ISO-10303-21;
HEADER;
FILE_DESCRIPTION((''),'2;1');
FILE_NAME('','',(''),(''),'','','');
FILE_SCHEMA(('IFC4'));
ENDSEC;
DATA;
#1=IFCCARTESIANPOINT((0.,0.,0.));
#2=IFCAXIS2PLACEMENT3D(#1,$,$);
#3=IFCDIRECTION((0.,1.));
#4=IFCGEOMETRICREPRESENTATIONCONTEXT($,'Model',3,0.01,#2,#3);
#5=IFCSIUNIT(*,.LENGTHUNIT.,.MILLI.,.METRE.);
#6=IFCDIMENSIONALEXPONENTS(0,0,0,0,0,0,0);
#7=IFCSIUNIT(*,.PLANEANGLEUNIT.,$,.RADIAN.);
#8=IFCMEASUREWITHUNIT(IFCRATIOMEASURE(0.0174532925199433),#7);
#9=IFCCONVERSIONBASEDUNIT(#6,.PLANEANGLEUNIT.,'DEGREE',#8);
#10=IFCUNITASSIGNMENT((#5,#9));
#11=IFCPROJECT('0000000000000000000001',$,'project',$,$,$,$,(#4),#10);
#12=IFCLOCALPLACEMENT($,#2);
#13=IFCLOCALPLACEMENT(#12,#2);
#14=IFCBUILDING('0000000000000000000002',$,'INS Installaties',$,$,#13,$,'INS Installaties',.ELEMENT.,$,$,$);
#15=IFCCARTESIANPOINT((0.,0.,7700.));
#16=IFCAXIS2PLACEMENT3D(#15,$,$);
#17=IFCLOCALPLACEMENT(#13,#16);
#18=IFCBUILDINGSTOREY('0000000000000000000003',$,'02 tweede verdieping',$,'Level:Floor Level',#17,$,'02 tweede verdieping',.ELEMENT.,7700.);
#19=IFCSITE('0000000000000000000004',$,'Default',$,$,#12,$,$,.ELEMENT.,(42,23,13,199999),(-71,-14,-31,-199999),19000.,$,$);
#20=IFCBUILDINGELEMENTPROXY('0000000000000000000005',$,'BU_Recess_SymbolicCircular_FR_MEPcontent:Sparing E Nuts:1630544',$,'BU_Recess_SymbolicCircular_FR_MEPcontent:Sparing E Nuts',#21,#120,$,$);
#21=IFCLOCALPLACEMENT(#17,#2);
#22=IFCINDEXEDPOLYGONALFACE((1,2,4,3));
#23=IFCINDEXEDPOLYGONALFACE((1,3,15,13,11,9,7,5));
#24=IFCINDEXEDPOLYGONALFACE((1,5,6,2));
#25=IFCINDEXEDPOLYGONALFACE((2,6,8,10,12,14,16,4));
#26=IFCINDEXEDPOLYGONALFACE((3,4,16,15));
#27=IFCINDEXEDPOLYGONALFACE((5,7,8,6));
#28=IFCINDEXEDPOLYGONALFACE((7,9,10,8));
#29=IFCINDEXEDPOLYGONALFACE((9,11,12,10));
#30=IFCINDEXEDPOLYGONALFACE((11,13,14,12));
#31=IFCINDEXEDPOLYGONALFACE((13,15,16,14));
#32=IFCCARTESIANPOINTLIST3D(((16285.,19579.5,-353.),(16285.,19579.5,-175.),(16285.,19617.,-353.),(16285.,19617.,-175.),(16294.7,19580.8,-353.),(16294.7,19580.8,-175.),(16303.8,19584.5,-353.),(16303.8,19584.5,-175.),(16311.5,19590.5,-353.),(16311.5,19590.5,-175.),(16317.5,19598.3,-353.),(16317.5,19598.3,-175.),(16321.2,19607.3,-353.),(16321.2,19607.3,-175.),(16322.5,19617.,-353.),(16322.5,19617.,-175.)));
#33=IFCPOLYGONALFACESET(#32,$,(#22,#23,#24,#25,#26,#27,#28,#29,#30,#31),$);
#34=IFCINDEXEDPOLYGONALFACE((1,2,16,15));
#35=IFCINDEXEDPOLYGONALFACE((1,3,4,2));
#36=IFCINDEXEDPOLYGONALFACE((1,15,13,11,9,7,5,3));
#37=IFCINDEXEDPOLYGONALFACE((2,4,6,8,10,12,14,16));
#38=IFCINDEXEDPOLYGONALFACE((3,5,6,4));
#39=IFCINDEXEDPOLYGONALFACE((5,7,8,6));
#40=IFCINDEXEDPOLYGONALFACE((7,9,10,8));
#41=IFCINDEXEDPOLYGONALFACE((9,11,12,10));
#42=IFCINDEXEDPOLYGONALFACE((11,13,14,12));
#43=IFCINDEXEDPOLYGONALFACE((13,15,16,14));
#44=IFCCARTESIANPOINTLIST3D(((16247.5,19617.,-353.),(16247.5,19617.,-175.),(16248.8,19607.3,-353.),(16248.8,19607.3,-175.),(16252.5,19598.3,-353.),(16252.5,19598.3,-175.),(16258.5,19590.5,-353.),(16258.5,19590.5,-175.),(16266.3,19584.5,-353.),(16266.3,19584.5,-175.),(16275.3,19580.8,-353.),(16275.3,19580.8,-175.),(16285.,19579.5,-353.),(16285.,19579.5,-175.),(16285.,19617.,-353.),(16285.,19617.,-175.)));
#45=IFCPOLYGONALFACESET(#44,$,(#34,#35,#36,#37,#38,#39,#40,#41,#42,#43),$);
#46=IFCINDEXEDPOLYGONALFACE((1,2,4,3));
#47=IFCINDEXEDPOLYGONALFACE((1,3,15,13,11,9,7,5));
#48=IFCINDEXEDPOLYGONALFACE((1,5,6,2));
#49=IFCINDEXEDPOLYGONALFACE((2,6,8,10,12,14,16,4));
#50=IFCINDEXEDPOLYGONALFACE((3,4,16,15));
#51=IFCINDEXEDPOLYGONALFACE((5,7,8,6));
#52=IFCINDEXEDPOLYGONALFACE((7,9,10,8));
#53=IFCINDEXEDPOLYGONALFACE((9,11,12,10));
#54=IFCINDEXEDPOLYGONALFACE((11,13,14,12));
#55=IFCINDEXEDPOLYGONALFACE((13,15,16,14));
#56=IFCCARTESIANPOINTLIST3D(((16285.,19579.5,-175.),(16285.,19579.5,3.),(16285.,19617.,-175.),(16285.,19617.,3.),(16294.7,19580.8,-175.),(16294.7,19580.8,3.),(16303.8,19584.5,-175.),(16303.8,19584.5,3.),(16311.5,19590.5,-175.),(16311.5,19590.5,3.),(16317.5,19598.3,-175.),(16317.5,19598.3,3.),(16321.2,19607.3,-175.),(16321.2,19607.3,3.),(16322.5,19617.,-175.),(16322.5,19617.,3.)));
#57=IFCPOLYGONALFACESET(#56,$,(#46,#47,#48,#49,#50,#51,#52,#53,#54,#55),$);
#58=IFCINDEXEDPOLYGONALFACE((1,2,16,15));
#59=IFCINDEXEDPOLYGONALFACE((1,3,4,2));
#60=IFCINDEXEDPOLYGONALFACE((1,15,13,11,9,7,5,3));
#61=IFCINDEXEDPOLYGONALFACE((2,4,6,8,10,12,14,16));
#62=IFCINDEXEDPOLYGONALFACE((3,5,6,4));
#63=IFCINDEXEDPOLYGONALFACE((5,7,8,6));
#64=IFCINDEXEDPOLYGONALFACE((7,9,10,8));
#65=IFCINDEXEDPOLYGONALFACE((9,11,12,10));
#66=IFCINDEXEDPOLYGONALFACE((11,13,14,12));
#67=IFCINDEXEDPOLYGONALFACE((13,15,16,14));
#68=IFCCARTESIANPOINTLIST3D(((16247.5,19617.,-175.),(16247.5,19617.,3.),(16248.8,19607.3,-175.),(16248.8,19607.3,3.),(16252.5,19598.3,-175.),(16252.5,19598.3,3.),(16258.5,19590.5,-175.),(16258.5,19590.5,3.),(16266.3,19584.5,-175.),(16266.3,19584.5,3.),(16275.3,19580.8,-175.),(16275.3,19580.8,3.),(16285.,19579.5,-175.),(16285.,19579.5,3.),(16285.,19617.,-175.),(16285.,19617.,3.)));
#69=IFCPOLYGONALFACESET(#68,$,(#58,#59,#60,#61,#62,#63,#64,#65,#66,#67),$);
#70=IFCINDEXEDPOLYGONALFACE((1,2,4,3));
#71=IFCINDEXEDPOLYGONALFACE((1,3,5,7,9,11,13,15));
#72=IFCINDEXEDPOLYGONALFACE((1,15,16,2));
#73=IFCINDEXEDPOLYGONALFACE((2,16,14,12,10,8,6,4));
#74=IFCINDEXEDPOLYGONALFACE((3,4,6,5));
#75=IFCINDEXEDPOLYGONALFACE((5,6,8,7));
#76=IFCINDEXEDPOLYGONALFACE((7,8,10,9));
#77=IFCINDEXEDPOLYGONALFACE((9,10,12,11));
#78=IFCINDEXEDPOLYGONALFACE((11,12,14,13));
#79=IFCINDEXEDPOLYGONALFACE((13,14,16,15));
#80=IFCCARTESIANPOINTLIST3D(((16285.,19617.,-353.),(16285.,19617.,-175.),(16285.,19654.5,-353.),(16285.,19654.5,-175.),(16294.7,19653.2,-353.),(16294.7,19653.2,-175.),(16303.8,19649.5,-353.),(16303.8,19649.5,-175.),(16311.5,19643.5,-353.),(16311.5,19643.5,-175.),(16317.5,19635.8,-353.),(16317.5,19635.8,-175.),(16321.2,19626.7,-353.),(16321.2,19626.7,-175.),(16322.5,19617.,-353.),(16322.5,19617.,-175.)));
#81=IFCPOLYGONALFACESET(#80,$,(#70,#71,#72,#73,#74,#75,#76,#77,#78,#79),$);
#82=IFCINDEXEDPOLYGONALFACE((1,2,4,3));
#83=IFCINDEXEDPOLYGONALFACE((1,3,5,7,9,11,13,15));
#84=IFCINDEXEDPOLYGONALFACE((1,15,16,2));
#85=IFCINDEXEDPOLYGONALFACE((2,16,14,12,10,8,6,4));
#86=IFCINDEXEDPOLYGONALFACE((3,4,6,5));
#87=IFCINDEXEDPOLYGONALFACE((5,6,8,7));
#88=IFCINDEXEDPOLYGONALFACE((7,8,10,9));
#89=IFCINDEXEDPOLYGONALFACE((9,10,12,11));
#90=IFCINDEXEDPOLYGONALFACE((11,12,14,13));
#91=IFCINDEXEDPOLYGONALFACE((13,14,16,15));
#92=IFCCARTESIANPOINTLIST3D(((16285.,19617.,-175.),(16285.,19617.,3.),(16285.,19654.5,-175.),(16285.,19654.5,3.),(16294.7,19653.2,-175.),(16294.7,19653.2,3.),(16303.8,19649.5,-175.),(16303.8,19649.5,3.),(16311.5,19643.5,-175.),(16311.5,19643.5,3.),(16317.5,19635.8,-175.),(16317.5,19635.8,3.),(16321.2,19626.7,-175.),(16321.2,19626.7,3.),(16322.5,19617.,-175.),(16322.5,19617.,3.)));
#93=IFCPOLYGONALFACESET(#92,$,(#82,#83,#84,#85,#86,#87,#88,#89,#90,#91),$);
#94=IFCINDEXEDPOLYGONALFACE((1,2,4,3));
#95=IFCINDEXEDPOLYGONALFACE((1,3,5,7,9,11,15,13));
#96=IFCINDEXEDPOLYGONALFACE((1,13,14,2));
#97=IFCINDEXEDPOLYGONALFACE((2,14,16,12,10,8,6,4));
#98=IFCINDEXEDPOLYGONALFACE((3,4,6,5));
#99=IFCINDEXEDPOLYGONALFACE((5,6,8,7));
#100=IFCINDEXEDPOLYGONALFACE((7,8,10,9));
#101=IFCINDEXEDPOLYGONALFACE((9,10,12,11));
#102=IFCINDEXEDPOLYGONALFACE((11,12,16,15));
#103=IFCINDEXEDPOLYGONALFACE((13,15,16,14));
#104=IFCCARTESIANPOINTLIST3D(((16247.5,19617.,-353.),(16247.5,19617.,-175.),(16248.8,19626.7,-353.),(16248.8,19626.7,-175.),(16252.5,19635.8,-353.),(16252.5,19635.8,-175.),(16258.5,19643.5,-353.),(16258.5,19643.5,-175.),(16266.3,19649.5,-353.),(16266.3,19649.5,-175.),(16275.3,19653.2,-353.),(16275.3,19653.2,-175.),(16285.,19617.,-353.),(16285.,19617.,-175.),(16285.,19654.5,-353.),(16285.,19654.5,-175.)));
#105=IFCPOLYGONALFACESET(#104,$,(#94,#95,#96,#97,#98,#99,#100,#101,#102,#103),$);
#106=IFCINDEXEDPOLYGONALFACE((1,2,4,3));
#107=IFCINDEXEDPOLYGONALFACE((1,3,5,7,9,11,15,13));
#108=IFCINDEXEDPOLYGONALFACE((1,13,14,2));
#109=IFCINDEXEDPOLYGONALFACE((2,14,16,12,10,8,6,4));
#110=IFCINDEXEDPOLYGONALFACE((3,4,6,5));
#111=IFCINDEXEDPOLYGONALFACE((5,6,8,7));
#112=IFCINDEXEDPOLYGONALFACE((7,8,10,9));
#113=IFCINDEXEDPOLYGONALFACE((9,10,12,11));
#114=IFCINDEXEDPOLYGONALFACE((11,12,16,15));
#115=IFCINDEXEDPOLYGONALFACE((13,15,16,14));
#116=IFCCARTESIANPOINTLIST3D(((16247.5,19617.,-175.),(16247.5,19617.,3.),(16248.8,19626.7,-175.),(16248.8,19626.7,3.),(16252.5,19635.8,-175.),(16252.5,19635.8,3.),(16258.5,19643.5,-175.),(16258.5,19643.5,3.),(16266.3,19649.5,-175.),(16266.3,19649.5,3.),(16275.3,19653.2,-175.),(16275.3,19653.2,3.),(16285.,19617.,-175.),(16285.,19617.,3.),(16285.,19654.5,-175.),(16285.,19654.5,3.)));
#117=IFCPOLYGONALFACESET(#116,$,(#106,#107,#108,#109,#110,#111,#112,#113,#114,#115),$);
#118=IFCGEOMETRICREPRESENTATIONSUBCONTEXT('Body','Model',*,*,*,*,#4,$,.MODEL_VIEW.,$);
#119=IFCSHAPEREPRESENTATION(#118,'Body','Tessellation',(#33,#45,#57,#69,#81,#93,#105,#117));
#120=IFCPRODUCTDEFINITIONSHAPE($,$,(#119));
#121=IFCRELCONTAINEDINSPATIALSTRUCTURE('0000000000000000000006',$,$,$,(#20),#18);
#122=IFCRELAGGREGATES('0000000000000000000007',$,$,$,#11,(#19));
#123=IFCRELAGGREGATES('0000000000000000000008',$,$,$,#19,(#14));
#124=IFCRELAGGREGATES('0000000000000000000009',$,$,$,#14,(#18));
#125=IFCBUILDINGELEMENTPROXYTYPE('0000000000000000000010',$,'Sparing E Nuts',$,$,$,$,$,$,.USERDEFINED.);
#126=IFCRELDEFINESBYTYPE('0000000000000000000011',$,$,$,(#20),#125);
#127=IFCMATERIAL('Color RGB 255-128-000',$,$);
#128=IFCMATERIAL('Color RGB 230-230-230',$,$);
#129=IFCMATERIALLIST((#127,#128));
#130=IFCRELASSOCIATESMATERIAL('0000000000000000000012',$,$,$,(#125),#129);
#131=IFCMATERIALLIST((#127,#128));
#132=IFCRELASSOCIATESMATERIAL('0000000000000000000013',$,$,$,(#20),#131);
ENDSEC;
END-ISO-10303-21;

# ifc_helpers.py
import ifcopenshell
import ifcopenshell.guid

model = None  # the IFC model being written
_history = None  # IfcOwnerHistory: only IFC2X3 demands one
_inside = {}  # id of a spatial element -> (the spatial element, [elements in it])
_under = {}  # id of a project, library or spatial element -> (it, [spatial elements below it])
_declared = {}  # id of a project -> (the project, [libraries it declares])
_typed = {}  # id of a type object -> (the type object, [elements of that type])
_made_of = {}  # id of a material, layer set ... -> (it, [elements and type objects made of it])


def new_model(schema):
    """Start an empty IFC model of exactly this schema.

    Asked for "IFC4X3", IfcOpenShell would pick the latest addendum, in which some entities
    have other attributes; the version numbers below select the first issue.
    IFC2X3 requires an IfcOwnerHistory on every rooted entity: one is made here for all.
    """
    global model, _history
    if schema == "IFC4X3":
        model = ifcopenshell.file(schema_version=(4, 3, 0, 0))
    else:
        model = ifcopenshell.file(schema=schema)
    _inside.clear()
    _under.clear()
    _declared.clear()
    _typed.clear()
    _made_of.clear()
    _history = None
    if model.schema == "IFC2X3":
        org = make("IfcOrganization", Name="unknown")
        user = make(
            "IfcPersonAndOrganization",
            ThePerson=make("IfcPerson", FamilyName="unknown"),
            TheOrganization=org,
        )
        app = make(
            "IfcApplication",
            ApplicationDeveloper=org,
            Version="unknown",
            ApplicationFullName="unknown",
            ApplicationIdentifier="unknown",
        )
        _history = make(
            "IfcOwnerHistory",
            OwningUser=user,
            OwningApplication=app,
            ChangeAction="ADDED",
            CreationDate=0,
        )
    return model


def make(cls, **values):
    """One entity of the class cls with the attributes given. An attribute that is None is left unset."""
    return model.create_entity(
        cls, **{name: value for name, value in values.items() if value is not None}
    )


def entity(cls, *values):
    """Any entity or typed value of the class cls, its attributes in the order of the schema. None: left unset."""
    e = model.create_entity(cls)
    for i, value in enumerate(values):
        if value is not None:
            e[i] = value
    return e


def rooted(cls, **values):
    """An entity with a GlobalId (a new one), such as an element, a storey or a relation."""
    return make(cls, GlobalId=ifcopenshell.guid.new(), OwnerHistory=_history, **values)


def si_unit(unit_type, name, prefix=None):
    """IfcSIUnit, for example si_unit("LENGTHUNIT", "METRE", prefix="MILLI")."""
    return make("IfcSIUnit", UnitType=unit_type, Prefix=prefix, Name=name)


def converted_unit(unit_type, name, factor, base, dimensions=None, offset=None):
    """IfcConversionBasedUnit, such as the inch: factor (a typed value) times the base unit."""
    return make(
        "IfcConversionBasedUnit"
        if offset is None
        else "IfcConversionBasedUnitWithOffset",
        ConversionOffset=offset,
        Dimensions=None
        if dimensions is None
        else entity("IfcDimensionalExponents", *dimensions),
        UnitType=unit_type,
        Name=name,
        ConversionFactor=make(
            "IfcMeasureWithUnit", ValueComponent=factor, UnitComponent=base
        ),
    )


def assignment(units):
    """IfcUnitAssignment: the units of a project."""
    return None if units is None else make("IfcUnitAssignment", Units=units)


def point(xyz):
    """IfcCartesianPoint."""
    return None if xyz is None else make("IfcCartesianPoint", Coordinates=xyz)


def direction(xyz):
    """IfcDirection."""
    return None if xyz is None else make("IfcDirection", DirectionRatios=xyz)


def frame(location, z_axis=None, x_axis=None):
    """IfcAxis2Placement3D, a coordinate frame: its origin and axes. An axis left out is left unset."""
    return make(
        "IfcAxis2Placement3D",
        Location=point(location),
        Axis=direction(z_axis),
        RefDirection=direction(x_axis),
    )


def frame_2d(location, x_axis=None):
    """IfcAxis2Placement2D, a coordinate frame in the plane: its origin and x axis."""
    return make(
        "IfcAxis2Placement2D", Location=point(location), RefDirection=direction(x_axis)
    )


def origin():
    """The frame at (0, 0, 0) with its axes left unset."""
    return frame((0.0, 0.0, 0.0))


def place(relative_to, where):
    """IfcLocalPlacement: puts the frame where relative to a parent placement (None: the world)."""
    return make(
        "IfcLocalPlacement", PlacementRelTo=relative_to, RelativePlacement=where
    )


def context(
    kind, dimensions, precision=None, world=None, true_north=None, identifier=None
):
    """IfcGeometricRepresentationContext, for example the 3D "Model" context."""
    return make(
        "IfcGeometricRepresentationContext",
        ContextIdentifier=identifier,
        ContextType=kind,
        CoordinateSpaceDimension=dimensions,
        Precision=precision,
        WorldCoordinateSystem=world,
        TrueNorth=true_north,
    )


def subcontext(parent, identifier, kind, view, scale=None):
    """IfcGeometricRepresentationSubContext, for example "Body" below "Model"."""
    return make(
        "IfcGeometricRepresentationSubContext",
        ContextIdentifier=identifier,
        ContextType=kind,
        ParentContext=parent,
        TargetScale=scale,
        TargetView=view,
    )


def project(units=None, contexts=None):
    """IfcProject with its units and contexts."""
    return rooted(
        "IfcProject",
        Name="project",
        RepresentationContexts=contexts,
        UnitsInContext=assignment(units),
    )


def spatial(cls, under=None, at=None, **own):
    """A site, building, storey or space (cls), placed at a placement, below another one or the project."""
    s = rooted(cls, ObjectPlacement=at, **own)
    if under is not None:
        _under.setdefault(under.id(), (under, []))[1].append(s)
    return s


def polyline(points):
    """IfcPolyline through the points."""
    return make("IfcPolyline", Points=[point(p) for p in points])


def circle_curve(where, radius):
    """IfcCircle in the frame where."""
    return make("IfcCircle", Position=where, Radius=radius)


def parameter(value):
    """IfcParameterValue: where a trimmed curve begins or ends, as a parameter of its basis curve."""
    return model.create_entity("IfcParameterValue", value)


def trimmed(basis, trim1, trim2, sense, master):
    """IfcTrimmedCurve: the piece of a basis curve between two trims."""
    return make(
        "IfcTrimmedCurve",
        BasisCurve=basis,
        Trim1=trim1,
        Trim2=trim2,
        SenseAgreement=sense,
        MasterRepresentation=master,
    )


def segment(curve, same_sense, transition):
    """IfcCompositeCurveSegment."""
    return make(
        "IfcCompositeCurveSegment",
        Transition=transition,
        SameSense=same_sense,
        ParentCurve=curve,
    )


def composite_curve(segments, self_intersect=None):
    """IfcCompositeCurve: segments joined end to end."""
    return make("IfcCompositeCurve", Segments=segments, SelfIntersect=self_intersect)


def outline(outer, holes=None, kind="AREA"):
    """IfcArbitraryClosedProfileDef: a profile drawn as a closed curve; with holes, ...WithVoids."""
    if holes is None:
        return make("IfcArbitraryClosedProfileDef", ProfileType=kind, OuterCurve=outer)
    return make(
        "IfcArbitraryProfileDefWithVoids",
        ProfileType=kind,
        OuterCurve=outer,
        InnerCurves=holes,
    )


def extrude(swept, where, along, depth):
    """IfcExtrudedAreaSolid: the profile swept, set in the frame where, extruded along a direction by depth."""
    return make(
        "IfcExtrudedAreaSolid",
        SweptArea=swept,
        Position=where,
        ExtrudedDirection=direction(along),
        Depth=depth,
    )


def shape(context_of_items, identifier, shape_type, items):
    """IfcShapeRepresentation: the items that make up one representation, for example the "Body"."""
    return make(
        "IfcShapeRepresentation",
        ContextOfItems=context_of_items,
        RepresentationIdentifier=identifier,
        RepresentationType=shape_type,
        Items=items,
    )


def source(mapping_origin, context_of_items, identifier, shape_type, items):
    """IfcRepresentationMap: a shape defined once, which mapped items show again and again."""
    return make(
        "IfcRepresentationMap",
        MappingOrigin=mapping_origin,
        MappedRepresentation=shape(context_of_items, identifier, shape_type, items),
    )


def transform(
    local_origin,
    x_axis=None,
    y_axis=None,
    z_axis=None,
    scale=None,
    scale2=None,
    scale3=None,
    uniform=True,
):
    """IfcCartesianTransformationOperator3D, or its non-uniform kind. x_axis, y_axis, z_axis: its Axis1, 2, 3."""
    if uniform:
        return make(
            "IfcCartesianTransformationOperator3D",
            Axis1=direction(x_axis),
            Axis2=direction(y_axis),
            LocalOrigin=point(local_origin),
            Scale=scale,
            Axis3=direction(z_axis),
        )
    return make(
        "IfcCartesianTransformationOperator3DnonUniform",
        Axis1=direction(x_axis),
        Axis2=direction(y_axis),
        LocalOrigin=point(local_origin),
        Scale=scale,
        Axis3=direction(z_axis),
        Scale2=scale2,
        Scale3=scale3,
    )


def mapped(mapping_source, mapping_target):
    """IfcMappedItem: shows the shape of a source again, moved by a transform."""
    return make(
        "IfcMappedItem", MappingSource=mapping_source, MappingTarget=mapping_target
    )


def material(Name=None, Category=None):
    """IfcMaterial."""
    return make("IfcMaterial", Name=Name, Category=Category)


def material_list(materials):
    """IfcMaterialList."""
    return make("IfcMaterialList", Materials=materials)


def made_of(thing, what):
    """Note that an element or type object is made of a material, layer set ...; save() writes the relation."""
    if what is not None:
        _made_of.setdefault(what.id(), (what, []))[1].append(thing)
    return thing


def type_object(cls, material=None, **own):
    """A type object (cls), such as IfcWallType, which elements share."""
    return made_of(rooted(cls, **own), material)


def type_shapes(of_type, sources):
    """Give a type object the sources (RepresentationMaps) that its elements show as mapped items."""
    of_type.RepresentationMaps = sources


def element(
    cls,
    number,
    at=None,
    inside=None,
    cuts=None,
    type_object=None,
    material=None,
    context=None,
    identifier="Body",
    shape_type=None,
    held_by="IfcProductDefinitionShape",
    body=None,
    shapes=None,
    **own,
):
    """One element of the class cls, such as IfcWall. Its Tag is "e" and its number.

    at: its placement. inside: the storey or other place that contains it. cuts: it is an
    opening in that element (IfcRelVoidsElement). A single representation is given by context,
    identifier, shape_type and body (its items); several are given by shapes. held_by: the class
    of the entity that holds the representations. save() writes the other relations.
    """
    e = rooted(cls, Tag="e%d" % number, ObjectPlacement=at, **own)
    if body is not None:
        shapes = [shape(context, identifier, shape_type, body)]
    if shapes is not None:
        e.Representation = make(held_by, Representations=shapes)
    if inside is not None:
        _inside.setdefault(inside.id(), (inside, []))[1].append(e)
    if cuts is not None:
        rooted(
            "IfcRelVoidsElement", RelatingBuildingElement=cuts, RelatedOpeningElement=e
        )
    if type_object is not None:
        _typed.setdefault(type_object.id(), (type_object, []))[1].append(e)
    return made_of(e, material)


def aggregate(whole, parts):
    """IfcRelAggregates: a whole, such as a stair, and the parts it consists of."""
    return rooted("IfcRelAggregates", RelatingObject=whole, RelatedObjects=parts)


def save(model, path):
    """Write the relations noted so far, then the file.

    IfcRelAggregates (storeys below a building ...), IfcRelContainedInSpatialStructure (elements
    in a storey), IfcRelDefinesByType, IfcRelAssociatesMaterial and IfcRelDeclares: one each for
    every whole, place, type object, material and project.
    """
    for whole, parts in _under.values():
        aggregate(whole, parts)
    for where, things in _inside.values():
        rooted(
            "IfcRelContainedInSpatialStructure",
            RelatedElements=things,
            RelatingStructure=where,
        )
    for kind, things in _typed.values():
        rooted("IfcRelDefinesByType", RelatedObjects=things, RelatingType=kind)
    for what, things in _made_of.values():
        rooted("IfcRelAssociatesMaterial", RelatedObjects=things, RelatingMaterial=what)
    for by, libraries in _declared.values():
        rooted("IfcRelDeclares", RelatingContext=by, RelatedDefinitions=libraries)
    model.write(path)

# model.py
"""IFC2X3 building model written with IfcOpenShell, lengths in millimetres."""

from ifc_helpers import new_model, entity, si_unit, converted_unit, direction, frame, frame_2d, origin, place, context, subcontext, project, spatial, polyline, circle_curve, parameter, trimmed, segment, composite_curve, outline, extrude, source, transform, mapped, material, material_list, type_object, type_shapes, element, save


model = new_model("IFC2X3")

# Units and contexts
model_context = context("Model", 3, precision=0.01, world=origin(), true_north=direction((0.0, 1.0)))
body_context = subcontext(model_context, "Body", "Model", "MODEL_VIEW")
ifc_project = project(units=[si_unit("LENGTHUNIT", "METRE", prefix="MILLI"), converted_unit("PLANEANGLEUNIT", "DEGREE", entity("IfcRatioMeasure", 0.0174532925199433), si_unit("PLANEANGLEUNIT", "RADIAN"), dimensions=[0, 0, 0, 0, 0, 0, 0])], contexts=[model_context])

# Site, building, storey
site_placement = place(None, origin())
site = spatial("IfcSite", under=ifc_project, at=site_placement, Name="Default", CompositionType="ELEMENT", RefLatitude=(42, 23, 13, 199999), RefLongitude=(-71, -14, -31, -199999), RefElevation=19000.0)
building_placement = place(site_placement, origin())
building = spatial("IfcBuilding", under=site, at=building_placement, Name="INS Installaties", LongName="INS Installaties", CompositionType="ELEMENT")
storey_placement = place(building_placement, frame((0.0, 0.0, 7700.0)))
storey = spatial("IfcBuildingStorey", under=building, at=storey_placement, Name="02 tweede verdieping", ObjectType="Level:Floor Level", LongName="02 tweede verdieping", CompositionType="ELEMENT", Elevation=7700.0)

# Building element proxy
ifc_material_1 = material(Name="Color RGB 255-128-000")
ifc_material_2 = material(Name="Color RGB 230-230-230")
ifc_material_list_1 = material_list([ifc_material_1, ifc_material_2])
building_element_proxy_type_1 = type_object("IfcBuildingElementProxyType", Name="Sparing E Nuts", PredefinedType="USERDEFINED", material=ifc_material_list_1)
shared_shape_1 = source(origin(), body_context, "Body", "SweptSolid", [
    extrude(outline(composite_curve([segment(polyline([(-25.0, -12.5), (12.5, -12.5)]), True, "CONTINUOUS"), segment(polyline([(12.5, -12.5), (12.5, 25.0)]), True, "CONTINUOUS"), segment(trimmed(circle_curve(frame_2d((12.5, -12.5), x_axis=(1.0, 0.0)), 37.5), [parameter(90.0)], [parameter(180.0)], True, "PARAMETER"), True, "CONTINUOUS")], self_intersect=False)), frame((12.5, -12.5, -353.0), z_axis=(0.0, 0.0, 1.0), x_axis=(-1.0, 0.0, 0.0)), (0.0, 0.0, 1.0), 178.0),
    extrude(outline(composite_curve([segment(trimmed(circle_curve(frame_2d((12.5, 12.5), x_axis=(1.0, 0.0)), 37.5), [parameter(180.0)], [parameter(270.0)], True, "PARAMETER"), True, "CONTINUOUS"), segment(polyline([(12.5, -25.0), (12.5, 12.5)]), True, "CONTINUOUS"), segment(polyline([(12.5, 12.5), (-25.0, 12.5)]), True, "CONTINUOUS")], self_intersect=False)), frame((-12.5, -12.5, -353.0)), (0.0, 0.0, 1.0), 178.0),
    extrude(outline(composite_curve([segment(polyline([(-25.0, -12.5), (12.5, -12.5)]), True, "CONTINUOUS"), segment(polyline([(12.5, -12.5), (12.5, 25.0)]), True, "CONTINUOUS"), segment(trimmed(circle_curve(frame_2d((12.5, -12.5), x_axis=(1.0, 0.0)), 37.5), [parameter(90.0)], [parameter(180.0)], True, "PARAMETER"), True, "CONTINUOUS")], self_intersect=False)), frame((12.5, -12.5, -175.0), z_axis=(0.0, 0.0, 1.0), x_axis=(-1.0, 0.0, 0.0)), (0.0, 0.0, 1.0), 178.0),
    extrude(outline(composite_curve([segment(trimmed(circle_curve(frame_2d((12.5, 12.5), x_axis=(1.0, 0.0)), 37.5), [parameter(180.0)], [parameter(270.0)], True, "PARAMETER"), True, "CONTINUOUS"), segment(polyline([(12.5, -25.0), (12.5, 12.5)]), True, "CONTINUOUS"), segment(polyline([(12.5, 12.5), (-25.0, 12.5)]), True, "CONTINUOUS")], self_intersect=False)), frame((-12.5, -12.5, -175.0)), (0.0, 0.0, 1.0), 178.0),
    extrude(outline(composite_curve([segment(trimmed(circle_curve(frame_2d((12.5, 12.5), x_axis=(1.0, 0.0)), 37.5), [parameter(180.0)], [parameter(270.0)], True, "PARAMETER"), True, "CONTINUOUS"), segment(polyline([(12.5, -25.0), (12.5, 12.5)]), True, "CONTINUOUS"), segment(polyline([(12.5, 12.5), (-25.0, 12.5)]), True, "CONTINUOUS")], self_intersect=False)), frame((12.5, 12.5, -353.0), z_axis=(0.0, 0.0, 1.0), x_axis=(-1.0, 0.0, 0.0)), (0.0, 0.0, 1.0), 178.0),
    extrude(outline(composite_curve([segment(trimmed(circle_curve(frame_2d((12.5, 12.5), x_axis=(1.0, 0.0)), 37.5), [parameter(180.0)], [parameter(270.0)], True, "PARAMETER"), True, "CONTINUOUS"), segment(polyline([(12.5, -25.0), (12.5, 12.5)]), True, "CONTINUOUS"), segment(polyline([(12.5, 12.5), (-25.0, 12.5)]), True, "CONTINUOUS")], self_intersect=False)), frame((12.5, 12.5, -175.0), z_axis=(0.0, 0.0, 1.0), x_axis=(-1.0, 0.0, 0.0)), (0.0, 0.0, 1.0), 178.0),
    extrude(outline(composite_curve([segment(polyline([(-25.0, -12.5), (12.5, -12.5)]), True, "CONTINUOUS"), segment(polyline([(12.5, -12.5), (12.5, 25.0)]), True, "CONTINUOUS"), segment(trimmed(circle_curve(frame_2d((12.5, -12.5), x_axis=(1.0, 0.0)), 37.5), [parameter(90.0)], [parameter(180.0)], True, "PARAMETER"), True, "CONTINUOUS")], self_intersect=False)), frame((-12.5, 12.5, -353.0)), (0.0, 0.0, 1.0), 178.0),
    extrude(outline(composite_curve([segment(polyline([(-25.0, -12.5), (12.5, -12.5)]), True, "CONTINUOUS"), segment(polyline([(12.5, -12.5), (12.5, 25.0)]), True, "CONTINUOUS"), segment(trimmed(circle_curve(frame_2d((12.5, -12.5), x_axis=(1.0, 0.0)), 37.5), [parameter(90.0)], [parameter(180.0)], True, "PARAMETER"), True, "CONTINUOUS")], self_intersect=False)), frame((-12.5, 12.5, -175.0)), (0.0, 0.0, 1.0), 178.0),
])
type_shapes(building_element_proxy_type_1, [shared_shape_1])
ifc_material_list_2 = material_list([ifc_material_1, ifc_material_2])
proxy_1_placement = place(storey_placement, frame((16285.0, 19617.0, 0.0)))
element("IfcBuildingElementProxy", 1, at=proxy_1_placement, inside=storey, type_object=building_element_proxy_type_1, material=ifc_material_list_2, Name="BU_Recess_SymbolicCircular_FR_MEPcontent:Sparing E Nuts:1630544", ObjectType="BU_Recess_SymbolicCircular_FR_MEPcontent:Sparing E Nuts", context=body_context, shape_type="MappedRepresentation", body=[
    mapped(shared_shape_1, transform((0.0, 0.0, 0.0), scale=1.0)),
])

save(model, "model.ifc")
